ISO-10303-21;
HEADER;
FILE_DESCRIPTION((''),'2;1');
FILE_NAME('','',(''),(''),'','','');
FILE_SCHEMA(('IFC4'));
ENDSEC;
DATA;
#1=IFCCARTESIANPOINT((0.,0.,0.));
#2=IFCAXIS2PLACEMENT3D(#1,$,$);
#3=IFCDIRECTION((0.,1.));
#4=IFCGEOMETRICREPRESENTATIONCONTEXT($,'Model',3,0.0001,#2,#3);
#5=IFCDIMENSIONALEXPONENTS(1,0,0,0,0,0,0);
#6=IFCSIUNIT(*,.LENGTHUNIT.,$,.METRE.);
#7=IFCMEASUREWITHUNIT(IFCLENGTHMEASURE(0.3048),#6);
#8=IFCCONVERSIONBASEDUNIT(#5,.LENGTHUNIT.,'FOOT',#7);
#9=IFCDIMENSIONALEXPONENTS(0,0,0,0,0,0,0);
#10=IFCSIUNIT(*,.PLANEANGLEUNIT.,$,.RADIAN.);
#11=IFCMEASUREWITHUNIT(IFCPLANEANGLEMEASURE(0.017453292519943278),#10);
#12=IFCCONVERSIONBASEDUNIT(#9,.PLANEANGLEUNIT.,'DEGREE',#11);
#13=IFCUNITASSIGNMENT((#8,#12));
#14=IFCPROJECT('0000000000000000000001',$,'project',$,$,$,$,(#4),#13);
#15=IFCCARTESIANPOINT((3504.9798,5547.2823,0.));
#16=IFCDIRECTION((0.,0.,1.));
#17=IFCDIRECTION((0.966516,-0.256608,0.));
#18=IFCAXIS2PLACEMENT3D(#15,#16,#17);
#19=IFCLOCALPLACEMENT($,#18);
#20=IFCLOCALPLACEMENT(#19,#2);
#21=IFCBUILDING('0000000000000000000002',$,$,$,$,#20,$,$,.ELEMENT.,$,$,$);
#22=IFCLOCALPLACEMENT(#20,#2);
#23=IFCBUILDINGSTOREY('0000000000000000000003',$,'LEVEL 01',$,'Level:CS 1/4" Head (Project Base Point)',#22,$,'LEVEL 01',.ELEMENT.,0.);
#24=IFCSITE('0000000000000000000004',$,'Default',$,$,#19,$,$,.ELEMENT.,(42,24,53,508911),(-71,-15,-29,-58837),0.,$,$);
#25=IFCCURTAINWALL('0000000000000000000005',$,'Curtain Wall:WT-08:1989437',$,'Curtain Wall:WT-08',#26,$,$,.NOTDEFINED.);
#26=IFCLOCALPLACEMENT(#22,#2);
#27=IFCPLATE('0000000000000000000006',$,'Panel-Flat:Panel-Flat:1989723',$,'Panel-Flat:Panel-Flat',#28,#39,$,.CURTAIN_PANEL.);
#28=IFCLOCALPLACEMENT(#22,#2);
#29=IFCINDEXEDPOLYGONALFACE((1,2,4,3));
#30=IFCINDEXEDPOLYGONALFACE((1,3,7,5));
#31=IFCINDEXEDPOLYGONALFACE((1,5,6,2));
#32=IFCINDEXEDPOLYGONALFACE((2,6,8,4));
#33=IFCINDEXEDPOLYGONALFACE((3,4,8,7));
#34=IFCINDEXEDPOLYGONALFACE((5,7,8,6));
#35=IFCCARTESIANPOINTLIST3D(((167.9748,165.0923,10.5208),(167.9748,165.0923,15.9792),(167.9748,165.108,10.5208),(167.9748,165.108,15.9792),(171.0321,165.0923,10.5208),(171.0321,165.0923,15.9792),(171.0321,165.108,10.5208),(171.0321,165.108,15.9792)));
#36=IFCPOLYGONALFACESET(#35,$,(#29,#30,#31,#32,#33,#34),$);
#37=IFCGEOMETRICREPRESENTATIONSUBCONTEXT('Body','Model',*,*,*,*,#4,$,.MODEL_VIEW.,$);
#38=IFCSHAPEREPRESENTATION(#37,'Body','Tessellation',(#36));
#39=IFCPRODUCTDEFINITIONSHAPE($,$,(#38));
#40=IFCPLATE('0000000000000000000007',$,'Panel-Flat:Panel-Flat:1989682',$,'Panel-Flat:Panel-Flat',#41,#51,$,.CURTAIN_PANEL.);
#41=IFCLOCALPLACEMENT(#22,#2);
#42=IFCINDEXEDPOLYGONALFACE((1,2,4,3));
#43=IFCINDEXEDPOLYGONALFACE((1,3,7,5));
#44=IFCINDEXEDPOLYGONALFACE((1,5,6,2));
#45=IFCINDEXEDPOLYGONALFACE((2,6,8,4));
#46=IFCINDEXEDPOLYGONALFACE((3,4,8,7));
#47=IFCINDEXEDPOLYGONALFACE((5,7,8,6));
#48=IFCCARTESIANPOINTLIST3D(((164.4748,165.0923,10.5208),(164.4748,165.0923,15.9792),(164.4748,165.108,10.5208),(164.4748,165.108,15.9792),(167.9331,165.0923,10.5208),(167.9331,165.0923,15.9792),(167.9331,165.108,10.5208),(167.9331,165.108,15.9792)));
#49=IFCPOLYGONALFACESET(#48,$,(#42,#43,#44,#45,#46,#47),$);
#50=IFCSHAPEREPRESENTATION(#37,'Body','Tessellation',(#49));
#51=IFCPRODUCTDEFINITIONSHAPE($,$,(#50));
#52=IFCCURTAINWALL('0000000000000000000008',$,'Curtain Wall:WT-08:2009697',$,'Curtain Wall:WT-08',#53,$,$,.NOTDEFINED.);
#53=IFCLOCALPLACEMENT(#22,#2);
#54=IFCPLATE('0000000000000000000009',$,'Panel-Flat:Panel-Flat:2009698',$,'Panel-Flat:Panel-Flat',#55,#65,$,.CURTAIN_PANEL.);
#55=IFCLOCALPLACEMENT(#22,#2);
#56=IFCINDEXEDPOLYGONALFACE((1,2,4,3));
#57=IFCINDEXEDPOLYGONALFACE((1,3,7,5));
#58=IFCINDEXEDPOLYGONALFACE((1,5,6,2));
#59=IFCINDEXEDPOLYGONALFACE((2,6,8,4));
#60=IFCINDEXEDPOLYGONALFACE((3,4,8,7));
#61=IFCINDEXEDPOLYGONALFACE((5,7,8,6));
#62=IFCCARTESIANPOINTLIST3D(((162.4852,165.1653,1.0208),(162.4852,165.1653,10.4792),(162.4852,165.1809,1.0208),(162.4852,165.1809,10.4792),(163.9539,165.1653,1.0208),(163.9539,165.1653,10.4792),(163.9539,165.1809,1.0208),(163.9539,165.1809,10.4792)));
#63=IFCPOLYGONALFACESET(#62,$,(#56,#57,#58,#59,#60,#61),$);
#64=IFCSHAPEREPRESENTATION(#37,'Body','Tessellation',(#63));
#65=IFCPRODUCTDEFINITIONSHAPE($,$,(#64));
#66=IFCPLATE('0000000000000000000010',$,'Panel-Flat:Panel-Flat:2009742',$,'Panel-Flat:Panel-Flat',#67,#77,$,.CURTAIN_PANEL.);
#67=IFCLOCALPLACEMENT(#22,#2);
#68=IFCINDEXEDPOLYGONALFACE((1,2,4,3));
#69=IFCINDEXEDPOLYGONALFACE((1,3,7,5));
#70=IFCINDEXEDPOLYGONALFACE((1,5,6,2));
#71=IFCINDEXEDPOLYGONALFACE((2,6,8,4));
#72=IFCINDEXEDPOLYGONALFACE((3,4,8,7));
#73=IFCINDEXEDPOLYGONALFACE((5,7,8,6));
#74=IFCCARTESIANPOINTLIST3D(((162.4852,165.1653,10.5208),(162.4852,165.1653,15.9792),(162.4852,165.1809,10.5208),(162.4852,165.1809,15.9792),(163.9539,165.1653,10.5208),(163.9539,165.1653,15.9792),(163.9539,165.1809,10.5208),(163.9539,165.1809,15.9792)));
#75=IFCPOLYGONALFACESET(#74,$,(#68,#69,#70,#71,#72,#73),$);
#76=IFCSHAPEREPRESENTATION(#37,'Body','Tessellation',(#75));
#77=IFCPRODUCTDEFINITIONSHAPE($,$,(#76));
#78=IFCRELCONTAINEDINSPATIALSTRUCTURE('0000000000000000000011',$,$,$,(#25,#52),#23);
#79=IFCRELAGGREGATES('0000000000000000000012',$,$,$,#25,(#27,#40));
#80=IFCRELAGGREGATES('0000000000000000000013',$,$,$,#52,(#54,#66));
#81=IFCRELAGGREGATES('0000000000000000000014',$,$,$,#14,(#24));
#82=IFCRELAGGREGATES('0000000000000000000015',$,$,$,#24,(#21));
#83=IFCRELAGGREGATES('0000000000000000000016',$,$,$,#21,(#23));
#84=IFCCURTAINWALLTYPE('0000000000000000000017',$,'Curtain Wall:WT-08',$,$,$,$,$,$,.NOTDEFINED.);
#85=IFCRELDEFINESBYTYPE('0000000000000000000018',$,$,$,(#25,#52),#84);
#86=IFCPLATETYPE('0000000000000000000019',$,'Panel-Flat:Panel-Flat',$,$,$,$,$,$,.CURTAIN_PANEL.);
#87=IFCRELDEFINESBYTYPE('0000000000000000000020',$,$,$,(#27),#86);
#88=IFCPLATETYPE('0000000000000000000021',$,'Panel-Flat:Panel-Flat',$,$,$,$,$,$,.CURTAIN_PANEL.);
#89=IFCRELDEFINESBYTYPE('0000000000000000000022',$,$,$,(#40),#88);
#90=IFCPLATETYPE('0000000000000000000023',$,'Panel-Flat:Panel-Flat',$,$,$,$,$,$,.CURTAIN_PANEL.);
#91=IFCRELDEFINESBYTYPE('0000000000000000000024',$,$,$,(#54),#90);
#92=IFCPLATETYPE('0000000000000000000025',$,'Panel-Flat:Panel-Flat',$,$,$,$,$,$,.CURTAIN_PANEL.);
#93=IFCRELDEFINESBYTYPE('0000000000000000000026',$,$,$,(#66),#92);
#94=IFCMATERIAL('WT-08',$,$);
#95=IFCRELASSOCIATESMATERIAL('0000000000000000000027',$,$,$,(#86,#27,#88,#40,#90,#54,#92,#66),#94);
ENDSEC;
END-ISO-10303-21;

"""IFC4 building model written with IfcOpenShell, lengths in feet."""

from ifc_helpers import new_model, entity, si_unit, converted_unit, direction, frame, origin, place, context, subcontext, project, spatial, indexed_curve, outline, extrude, source, transform, mapped, material, type_object, type_shapes, element, aggregate, save


model = new_model("IFC4")

# Units and contexts
model_context = context("Model", 3, precision=0.0001, world=origin(), true_north=direction((0.0, 1.0)))
body_context = subcontext(model_context, "Body", "Model", "MODEL_VIEW")
ifc_project = project(units=[converted_unit("LENGTHUNIT", "FOOT", entity("IfcLengthMeasure", 0.3048), si_unit("LENGTHUNIT", "METRE"), dimensions=[1, 0, 0, 0, 0, 0, 0]), converted_unit("PLANEANGLEUNIT", "DEGREE", entity("IfcPlaneAngleMeasure", 0.017453292519943278), si_unit("PLANEANGLEUNIT", "RADIAN"), dimensions=[0, 0, 0, 0, 0, 0, 0])], contexts=[model_context])

# Site, building, storey
site_placement = place(None, frame((3504.9798, 5547.2823, 0.0), z_axis=(0.0, 0.0, 1.0), x_axis=(0.966516, -0.256608, 0.0)))
site = spatial("IfcSite", under=ifc_project, at=site_placement, Name="Default", CompositionType="ELEMENT", RefLatitude=(42, 24, 53, 508911), RefLongitude=(-71, -15, -29, -58837), RefElevation=0.0)
building_placement = place(site_placement, origin())
building = spatial("IfcBuilding", under=site, at=building_placement, CompositionType="ELEMENT")
storey_placement = place(building_placement, origin())
storey = spatial("IfcBuildingStorey", under=building, at=storey_placement, Name="LEVEL 01", ObjectType="Level:CS 1/4\" Head (Project Base Point)", LongName="LEVEL 01", CompositionType="ELEMENT", Elevation=0.0)

# Curtain wall, plates
curtain_wall_type_1 = type_object("IfcCurtainWallType", Name="Curtain Wall:WT-08", PredefinedType="NOTDEFINED")
curtain_wall_1_placement = place(storey_placement, origin())
curtain_wall_1 = element("IfcCurtainWall", 1, at=curtain_wall_1_placement, inside=storey, type_object=curtain_wall_type_1, Name="Curtain Wall:WT-08:1989437", ObjectType="Curtain Wall:WT-08", PredefinedType="NOTDEFINED")
ifc_material_1 = material(Name="WT-08")
plate_type_1 = type_object("IfcPlateType", Name="Panel-Flat:Panel-Flat", PredefinedType="CURTAIN_PANEL", material=ifc_material_1)
shared_shape_1 = source(origin(), body_context, "Body", "SweptSolid", [
    extrude(outline(indexed_curve([(-0.0078, -1.5287), (0.0078, -1.5287), (0.0078, 1.5287), (-0.0078, 1.5287), (-0.0078, -1.5287)], self_intersect=False)), frame((0.0, -0.0078, 0.0208), z_axis=(0.0, 0.0, 1.0), x_axis=(0.0, -1.0, 0.0)), (0.0, 0.0, 1.0), 5.4583),
])
type_shapes(plate_type_1, [shared_shape_1])
plate_1_placement = place(curtain_wall_1_placement, frame((169.5035, 165.0923, 10.5), z_axis=(0.0, 0.0, 1.0), x_axis=(-1.0, 0.0, 0.0)))
plate_1 = element("IfcPlate", 2, at=plate_1_placement, type_object=plate_type_1, material=ifc_material_1, Name="Panel-Flat:Panel-Flat:1989723", ObjectType="Panel-Flat:Panel-Flat", PredefinedType="CURTAIN_PANEL", context=body_context, shape_type="MappedRepresentation", body=[
    mapped(shared_shape_1, transform((0.0, 0.0, 0.0), scale=1.0)),
])
plate_type_2 = type_object("IfcPlateType", Name="Panel-Flat:Panel-Flat", PredefinedType="CURTAIN_PANEL", material=ifc_material_1)
shared_shape_2 = source(origin(), body_context, "Body", "SweptSolid", [
    extrude(outline(indexed_curve([(-0.0078, -1.7292), (0.0078, -1.7292), (0.0078, 1.7292), (-0.0078, 1.7292), (-0.0078, -1.7292)], self_intersect=False)), frame((0.0, -0.0078, 0.0208), z_axis=(0.0, 0.0, 1.0), x_axis=(0.0, -1.0, 0.0)), (0.0, 0.0, 1.0), 5.4583),
])
type_shapes(plate_type_2, [shared_shape_2])
plate_2_placement = place(curtain_wall_1_placement, frame((166.2039, 165.0923, 10.5), z_axis=(0.0, 0.0, 1.0), x_axis=(-1.0, 0.0, 0.0)))
plate_2 = element("IfcPlate", 3, at=plate_2_placement, type_object=plate_type_2, material=ifc_material_1, Name="Panel-Flat:Panel-Flat:1989682", ObjectType="Panel-Flat:Panel-Flat", PredefinedType="CURTAIN_PANEL", context=body_context, shape_type="MappedRepresentation", body=[
    mapped(shared_shape_2, transform((0.0, 0.0, 0.0), scale=1.0)),
])
aggregate(curtain_wall_1, [plate_1, plate_2])

# Curtain wall, plates
curtain_wall_2_placement = place(storey_placement, origin())
curtain_wall_2 = element("IfcCurtainWall", 4, at=curtain_wall_2_placement, inside=storey, type_object=curtain_wall_type_1, Name="Curtain Wall:WT-08:2009697", ObjectType="Curtain Wall:WT-08", PredefinedType="NOTDEFINED")
plate_type_3 = type_object("IfcPlateType", Name="Panel-Flat:Panel-Flat", PredefinedType="CURTAIN_PANEL", material=ifc_material_1)
shared_shape_3 = source(origin(), body_context, "Body", "SweptSolid", [
    extrude(outline(indexed_curve([(-0.0078, -0.7344), (0.0078, -0.7344), (0.0078, 0.7344), (-0.0078, 0.7344), (-0.0078, -0.7344)], self_intersect=False)), frame((0.0, -0.0078, 0.0208), z_axis=(0.0, 0.0, 1.0), x_axis=(0.0, -1.0, 0.0)), (0.0, 0.0, 1.0), 9.4583),
])
type_shapes(plate_type_3, [shared_shape_3])
plate_3_placement = place(curtain_wall_2_placement, frame((163.2196, 165.1653, 1.0), z_axis=(0.0, 0.0, 1.0), x_axis=(-1.0, 0.0, 0.0)))
plate_3 = element("IfcPlate", 5, at=plate_3_placement, type_object=plate_type_3, material=ifc_material_1, Name="Panel-Flat:Panel-Flat:2009698", ObjectType="Panel-Flat:Panel-Flat", PredefinedType="CURTAIN_PANEL", context=body_context, shape_type="MappedRepresentation", body=[
    mapped(shared_shape_3, transform((0.0, 0.0, 0.0), scale=1.0)),
])
plate_type_4 = type_object("IfcPlateType", Name="Panel-Flat:Panel-Flat", PredefinedType="CURTAIN_PANEL", material=ifc_material_1)
shared_shape_4 = source(origin(), body_context, "Body", "SweptSolid", [
    extrude(outline(indexed_curve([(-0.0078, -0.7344), (0.0078, -0.7344), (0.0078, 0.7344), (-0.0078, 0.7344), (-0.0078, -0.7344)], self_intersect=False)), frame((0.0, -0.0078, 0.0208), z_axis=(0.0, 0.0, 1.0), x_axis=(0.0, -1.0, 0.0)), (0.0, 0.0, 1.0), 5.4583),
])
type_shapes(plate_type_4, [shared_shape_4])
plate_4_placement = place(curtain_wall_2_placement, frame((163.2196, 165.1653, 10.5), z_axis=(0.0, 0.0, 1.0), x_axis=(-1.0, 0.0, 0.0)))
plate_4 = element("IfcPlate", 6, at=plate_4_placement, type_object=plate_type_4, material=ifc_material_1, Name="Panel-Flat:Panel-Flat:2009742", ObjectType="Panel-Flat:Panel-Flat", PredefinedType="CURTAIN_PANEL", context=body_context, shape_type="MappedRepresentation", body=[
    mapped(shared_shape_4, transform((0.0, 0.0, 0.0), scale=1.0)),
])
aggregate(curtain_wall_2, [plate_3, plate_4])

save(model, "model.ifc")
